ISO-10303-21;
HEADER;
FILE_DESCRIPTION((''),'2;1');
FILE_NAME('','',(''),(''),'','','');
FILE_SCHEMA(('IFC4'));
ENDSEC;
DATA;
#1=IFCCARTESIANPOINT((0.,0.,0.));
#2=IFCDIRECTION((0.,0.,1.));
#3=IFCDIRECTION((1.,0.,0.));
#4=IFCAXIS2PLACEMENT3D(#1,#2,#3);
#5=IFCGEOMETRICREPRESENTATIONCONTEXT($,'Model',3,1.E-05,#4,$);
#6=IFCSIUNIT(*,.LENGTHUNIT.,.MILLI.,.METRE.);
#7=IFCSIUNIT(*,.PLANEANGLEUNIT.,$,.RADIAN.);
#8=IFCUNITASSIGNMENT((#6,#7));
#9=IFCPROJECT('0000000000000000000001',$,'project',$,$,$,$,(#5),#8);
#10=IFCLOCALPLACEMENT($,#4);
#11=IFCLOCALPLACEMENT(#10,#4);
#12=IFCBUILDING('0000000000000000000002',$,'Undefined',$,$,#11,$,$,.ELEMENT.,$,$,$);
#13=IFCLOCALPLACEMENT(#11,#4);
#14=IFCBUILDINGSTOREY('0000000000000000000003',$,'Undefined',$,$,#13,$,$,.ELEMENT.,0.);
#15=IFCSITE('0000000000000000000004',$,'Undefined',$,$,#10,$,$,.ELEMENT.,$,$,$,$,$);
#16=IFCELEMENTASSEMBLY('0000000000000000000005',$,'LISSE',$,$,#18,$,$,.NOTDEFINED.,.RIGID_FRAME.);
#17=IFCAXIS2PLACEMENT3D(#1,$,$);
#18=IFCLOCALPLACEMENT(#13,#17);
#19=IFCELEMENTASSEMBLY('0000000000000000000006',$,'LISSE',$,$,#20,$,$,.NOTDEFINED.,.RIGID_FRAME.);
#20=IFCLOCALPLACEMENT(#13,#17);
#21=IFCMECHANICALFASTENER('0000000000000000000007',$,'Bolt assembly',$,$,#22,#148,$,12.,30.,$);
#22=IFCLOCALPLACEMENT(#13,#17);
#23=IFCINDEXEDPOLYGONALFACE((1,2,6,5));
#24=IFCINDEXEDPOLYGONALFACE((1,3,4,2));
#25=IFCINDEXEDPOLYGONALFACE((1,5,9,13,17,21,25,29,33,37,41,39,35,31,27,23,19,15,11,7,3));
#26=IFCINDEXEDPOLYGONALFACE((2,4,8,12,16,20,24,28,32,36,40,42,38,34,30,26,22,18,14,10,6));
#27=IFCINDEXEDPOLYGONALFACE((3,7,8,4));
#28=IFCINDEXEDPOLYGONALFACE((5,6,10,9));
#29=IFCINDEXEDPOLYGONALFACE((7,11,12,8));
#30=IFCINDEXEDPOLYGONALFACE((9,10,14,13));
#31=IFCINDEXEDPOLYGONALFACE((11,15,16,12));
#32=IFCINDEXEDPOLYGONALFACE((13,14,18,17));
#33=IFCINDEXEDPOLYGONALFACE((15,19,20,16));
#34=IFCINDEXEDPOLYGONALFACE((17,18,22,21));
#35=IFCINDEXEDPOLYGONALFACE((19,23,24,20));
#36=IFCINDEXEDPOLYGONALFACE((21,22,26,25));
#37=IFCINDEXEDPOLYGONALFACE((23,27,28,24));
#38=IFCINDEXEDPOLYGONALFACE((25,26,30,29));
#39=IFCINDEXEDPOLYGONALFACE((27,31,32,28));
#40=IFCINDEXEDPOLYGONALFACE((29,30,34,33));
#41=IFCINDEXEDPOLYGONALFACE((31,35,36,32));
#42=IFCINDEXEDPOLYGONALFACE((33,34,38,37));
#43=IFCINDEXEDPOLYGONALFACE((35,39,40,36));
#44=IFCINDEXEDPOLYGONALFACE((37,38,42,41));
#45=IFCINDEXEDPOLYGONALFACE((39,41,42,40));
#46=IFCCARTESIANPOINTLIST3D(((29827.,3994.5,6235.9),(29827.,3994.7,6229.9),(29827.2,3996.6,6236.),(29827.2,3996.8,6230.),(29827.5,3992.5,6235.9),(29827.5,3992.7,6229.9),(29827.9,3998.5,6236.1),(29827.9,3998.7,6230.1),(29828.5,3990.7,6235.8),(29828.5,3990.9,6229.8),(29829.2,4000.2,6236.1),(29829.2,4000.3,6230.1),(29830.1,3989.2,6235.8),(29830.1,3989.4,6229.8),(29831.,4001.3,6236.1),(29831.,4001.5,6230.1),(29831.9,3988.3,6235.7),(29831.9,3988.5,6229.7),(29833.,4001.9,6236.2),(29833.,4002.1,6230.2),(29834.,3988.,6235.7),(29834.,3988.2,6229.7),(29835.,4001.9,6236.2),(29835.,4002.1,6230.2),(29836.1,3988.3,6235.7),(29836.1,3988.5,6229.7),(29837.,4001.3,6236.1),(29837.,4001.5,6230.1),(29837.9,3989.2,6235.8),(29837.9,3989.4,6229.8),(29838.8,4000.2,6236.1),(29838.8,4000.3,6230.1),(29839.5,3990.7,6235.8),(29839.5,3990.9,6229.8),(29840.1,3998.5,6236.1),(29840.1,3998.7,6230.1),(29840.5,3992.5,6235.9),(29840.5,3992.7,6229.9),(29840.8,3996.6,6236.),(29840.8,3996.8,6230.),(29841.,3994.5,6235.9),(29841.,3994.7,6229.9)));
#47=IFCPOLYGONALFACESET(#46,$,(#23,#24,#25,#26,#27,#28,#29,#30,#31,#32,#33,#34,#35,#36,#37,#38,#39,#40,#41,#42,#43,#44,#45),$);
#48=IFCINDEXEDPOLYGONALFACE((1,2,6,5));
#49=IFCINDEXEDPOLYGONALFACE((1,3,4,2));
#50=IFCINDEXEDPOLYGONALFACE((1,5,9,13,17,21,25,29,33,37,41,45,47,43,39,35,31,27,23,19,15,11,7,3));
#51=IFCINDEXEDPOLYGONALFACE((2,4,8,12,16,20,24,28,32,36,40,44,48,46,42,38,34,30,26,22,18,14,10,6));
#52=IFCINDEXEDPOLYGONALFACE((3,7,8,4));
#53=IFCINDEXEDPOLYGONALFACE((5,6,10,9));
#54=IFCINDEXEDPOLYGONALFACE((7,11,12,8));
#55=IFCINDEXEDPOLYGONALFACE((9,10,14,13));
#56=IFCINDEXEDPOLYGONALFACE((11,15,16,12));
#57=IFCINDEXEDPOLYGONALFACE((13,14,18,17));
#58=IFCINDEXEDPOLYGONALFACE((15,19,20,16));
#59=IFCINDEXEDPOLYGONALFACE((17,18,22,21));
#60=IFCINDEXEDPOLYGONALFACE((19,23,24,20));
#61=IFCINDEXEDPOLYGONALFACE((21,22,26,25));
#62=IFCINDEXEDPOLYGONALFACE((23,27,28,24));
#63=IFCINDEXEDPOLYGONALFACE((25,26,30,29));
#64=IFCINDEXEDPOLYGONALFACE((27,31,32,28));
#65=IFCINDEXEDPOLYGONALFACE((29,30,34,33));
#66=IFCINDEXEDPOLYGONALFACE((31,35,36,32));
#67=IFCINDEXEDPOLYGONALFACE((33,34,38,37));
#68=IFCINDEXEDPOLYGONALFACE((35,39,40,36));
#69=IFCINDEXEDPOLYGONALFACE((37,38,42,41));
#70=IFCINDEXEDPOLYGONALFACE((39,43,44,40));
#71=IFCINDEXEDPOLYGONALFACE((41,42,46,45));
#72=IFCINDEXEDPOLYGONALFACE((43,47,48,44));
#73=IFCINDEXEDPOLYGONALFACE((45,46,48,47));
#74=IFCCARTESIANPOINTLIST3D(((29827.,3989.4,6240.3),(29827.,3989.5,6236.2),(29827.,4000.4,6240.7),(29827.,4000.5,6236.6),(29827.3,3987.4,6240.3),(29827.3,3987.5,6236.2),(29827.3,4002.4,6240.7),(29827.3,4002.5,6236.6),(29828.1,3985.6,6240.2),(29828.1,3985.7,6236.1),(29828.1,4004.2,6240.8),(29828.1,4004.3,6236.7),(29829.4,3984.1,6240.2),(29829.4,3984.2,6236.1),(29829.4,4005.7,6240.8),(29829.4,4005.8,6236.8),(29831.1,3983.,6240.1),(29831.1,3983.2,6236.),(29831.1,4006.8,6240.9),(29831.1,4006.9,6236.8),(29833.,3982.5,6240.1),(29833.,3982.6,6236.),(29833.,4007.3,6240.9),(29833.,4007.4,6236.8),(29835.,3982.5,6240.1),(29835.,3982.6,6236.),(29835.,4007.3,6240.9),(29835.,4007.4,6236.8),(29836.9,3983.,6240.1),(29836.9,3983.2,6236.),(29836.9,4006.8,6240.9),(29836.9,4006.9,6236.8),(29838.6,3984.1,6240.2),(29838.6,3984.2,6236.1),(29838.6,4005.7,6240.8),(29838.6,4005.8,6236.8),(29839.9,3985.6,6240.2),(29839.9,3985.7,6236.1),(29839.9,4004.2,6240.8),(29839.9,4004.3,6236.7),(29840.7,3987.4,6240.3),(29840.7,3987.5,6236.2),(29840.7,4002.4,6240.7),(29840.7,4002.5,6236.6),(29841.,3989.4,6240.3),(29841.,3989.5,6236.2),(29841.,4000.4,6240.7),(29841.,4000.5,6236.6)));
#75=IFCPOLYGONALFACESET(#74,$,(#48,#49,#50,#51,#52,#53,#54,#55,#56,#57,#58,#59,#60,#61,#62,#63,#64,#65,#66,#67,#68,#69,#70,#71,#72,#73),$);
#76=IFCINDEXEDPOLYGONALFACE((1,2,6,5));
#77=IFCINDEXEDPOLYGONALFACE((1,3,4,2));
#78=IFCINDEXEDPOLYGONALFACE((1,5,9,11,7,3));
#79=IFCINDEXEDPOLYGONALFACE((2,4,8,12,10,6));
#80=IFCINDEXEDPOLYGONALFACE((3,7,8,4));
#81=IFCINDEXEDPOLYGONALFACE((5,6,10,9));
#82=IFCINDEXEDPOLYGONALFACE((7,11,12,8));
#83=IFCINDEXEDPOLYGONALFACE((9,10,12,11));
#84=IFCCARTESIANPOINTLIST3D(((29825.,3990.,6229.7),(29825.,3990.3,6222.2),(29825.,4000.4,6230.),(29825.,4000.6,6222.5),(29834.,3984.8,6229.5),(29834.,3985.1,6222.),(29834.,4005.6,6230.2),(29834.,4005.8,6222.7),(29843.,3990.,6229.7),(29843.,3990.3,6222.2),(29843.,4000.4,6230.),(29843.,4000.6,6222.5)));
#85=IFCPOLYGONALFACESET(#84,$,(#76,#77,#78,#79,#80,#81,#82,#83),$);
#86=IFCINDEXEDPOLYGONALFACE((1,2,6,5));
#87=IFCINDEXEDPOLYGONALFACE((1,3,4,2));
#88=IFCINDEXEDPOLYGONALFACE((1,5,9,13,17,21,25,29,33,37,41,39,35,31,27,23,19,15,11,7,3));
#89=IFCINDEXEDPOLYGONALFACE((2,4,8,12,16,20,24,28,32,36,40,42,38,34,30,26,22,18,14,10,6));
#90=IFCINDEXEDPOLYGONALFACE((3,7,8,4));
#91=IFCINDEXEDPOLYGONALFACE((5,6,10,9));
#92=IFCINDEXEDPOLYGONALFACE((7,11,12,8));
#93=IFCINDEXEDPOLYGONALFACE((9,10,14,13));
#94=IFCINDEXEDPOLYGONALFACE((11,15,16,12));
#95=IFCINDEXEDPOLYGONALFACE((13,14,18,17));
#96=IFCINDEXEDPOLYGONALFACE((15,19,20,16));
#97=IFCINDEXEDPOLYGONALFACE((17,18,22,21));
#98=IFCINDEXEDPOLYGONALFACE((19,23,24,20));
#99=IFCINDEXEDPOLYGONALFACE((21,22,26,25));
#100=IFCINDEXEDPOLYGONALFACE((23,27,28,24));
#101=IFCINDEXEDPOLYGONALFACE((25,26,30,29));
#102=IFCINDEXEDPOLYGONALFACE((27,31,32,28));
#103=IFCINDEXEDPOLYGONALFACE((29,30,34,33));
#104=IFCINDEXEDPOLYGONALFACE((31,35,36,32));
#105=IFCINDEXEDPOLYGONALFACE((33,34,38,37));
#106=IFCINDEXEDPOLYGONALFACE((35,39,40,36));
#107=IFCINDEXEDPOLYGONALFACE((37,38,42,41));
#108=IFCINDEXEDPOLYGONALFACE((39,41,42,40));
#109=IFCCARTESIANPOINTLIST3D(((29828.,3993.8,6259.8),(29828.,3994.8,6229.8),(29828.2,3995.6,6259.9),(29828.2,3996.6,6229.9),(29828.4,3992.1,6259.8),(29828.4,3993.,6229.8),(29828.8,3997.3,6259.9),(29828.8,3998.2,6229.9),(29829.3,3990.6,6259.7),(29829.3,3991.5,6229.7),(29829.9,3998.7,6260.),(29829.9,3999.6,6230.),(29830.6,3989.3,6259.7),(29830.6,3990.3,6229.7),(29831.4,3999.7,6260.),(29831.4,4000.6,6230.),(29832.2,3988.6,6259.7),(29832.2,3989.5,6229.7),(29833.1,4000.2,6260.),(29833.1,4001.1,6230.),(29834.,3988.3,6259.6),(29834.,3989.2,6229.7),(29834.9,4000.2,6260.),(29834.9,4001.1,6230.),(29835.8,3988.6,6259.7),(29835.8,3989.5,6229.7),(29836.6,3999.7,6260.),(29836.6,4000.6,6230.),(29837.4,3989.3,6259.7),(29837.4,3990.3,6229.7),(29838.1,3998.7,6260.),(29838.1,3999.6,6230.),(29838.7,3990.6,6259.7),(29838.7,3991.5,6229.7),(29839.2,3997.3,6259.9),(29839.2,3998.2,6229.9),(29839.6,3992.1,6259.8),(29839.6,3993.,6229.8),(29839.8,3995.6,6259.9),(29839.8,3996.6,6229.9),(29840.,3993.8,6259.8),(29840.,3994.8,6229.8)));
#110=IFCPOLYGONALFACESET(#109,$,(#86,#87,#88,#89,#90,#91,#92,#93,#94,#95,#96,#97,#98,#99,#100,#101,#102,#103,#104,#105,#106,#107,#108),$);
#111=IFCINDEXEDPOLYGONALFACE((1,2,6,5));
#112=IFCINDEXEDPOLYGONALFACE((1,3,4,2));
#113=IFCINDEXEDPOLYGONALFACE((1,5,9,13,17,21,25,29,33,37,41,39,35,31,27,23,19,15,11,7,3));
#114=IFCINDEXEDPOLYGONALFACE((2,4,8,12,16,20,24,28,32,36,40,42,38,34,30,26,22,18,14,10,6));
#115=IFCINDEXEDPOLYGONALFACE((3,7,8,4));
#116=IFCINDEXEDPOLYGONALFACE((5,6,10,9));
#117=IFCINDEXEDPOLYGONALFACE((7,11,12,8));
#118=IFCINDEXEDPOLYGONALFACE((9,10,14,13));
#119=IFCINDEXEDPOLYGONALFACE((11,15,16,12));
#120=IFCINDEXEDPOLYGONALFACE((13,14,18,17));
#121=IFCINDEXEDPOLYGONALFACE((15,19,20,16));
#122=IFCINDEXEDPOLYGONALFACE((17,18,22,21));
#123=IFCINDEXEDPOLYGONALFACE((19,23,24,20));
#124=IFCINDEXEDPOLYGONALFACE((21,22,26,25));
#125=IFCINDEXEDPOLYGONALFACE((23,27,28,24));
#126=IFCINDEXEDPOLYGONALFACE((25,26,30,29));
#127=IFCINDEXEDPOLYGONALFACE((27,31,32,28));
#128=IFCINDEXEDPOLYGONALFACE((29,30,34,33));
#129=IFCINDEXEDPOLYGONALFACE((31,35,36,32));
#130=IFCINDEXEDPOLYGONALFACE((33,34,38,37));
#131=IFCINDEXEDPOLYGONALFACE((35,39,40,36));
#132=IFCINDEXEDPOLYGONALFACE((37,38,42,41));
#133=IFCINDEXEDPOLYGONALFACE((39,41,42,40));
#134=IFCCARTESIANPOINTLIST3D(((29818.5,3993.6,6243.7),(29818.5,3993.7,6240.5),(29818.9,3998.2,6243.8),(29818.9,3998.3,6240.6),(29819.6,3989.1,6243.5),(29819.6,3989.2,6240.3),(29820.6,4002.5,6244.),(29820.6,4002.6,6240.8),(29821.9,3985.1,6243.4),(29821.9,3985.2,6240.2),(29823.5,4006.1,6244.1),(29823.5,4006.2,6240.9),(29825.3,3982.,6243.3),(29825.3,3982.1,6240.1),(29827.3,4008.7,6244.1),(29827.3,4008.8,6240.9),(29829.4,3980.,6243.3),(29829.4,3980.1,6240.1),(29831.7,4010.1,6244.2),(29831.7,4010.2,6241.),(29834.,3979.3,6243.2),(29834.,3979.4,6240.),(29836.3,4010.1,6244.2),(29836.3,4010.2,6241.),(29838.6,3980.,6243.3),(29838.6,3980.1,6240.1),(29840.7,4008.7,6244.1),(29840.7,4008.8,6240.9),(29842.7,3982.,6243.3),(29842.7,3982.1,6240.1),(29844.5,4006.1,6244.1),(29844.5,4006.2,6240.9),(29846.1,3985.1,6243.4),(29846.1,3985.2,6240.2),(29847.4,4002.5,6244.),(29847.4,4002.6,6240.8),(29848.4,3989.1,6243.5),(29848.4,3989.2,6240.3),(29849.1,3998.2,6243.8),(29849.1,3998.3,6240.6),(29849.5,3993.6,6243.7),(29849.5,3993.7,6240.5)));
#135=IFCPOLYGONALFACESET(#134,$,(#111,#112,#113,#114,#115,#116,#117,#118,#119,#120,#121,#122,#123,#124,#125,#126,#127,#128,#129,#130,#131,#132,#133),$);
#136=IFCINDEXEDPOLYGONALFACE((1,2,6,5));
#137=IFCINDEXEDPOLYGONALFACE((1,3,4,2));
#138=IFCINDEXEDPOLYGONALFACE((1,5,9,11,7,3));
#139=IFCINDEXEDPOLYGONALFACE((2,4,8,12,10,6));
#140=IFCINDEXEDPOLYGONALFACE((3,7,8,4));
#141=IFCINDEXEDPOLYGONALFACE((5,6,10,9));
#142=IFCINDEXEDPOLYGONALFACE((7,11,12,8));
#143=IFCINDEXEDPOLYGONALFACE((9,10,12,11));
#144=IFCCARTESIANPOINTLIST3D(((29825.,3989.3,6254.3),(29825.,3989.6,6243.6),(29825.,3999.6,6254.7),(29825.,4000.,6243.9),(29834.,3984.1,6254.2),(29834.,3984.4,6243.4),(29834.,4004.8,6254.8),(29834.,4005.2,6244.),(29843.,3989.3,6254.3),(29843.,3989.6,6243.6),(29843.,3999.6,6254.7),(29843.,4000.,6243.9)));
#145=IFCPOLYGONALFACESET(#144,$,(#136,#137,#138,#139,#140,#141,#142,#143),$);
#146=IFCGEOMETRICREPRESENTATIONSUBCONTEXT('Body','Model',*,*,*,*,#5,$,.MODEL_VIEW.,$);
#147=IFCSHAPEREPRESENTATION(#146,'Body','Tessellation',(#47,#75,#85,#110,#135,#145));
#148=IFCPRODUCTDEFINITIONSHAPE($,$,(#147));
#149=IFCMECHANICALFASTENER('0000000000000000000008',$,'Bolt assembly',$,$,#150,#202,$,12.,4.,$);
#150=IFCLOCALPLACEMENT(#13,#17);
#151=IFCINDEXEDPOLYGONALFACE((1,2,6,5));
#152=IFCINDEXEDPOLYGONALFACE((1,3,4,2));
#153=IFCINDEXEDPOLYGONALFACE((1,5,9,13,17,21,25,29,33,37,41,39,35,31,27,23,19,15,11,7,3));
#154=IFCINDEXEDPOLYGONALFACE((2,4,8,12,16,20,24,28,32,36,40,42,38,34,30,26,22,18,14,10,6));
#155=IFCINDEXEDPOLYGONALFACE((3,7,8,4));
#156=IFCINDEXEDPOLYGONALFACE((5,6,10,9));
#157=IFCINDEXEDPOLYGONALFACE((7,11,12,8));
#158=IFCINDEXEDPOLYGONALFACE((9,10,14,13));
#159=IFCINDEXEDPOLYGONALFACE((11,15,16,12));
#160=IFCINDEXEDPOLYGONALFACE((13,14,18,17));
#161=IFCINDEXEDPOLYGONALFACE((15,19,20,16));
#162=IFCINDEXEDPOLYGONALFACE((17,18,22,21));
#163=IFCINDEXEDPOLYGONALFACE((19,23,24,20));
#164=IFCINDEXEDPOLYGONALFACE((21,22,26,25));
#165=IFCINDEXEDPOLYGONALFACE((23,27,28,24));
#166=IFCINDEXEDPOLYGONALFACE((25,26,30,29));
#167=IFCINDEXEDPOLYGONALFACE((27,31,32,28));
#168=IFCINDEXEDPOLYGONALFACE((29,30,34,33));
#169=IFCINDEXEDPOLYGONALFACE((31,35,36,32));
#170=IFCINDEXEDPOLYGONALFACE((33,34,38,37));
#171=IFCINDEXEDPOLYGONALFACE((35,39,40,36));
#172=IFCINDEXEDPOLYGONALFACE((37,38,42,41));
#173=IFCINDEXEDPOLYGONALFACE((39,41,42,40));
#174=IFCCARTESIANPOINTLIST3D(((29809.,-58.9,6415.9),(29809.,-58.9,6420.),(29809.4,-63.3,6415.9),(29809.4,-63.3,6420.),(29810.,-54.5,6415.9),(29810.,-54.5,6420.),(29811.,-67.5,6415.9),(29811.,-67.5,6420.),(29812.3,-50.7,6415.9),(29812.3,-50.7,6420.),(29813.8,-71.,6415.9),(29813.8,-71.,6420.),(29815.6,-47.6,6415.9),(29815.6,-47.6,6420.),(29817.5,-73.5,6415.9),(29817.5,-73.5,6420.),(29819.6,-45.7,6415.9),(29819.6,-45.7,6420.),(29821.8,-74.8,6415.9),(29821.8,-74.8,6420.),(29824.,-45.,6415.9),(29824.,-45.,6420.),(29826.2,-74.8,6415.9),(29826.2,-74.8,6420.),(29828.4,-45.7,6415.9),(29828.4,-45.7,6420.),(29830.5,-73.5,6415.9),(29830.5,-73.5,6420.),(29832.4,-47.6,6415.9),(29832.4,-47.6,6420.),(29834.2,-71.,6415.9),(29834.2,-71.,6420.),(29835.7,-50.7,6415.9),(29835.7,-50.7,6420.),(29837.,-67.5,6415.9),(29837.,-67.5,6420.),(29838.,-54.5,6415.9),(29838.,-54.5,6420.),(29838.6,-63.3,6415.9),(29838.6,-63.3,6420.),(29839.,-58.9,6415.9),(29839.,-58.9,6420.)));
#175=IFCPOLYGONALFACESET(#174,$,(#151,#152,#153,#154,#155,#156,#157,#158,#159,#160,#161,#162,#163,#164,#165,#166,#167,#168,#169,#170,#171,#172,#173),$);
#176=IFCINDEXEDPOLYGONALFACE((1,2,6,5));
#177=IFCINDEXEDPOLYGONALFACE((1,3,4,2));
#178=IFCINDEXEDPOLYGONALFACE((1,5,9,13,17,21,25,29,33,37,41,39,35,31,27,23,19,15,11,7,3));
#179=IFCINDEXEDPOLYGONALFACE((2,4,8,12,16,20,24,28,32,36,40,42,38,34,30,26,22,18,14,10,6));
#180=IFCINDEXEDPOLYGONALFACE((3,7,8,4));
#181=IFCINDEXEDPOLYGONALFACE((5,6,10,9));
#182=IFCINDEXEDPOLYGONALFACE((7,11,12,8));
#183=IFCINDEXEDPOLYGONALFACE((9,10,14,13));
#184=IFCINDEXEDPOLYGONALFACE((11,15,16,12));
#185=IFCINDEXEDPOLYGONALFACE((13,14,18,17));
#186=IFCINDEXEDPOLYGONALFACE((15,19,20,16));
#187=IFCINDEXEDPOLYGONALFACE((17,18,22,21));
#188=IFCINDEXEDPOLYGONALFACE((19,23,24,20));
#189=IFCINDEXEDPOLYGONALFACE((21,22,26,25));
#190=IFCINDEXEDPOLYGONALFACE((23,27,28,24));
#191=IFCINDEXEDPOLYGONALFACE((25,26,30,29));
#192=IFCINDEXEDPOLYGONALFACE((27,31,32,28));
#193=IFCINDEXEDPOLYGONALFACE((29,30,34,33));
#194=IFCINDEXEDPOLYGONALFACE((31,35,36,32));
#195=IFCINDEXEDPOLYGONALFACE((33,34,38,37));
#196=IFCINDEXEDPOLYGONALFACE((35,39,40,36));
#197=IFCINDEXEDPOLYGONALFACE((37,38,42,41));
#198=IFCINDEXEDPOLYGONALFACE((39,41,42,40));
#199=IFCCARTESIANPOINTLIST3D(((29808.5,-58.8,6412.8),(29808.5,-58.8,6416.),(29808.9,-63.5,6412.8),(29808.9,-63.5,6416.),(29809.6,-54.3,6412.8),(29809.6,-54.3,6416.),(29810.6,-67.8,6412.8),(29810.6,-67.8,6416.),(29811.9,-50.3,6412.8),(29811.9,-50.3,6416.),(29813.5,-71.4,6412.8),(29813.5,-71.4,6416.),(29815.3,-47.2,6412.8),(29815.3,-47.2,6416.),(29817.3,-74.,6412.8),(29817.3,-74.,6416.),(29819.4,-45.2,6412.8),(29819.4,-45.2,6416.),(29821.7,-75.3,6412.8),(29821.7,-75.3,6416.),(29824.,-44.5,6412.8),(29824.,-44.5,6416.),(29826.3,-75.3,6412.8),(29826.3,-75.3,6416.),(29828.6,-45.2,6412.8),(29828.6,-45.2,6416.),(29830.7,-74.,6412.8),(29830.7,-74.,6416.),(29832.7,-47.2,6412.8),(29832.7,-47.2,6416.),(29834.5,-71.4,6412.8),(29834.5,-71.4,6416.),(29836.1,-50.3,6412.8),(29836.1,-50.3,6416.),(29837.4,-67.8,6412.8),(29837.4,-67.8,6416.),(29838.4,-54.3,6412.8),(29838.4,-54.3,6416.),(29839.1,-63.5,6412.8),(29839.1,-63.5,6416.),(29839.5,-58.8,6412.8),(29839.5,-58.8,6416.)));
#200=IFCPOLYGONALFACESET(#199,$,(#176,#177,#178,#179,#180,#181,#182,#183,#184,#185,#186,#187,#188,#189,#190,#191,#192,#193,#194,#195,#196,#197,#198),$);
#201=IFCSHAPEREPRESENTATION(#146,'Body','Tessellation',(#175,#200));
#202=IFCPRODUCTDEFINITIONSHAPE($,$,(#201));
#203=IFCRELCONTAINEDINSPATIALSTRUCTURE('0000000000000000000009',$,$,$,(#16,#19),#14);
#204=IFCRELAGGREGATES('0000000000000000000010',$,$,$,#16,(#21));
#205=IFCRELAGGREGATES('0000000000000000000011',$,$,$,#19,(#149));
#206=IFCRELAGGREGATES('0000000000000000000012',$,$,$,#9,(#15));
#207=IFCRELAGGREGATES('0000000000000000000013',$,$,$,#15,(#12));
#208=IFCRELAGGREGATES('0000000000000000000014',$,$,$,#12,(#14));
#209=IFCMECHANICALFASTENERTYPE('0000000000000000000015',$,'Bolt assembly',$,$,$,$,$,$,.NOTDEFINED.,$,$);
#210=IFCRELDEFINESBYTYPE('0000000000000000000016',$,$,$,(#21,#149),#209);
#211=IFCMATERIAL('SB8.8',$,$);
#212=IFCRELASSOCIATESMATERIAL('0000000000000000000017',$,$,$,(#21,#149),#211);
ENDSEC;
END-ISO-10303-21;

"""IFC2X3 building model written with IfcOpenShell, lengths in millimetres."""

from ifc_helpers import new_model, si_unit, frame, frame_2d, origin_with_axes, origin_2d_with_axis, place, context, subcontext, project, spatial, polyline, circle_curve, parameter, trimmed, segment, composite_curve, circle, outline, extrude, source, transform, mapped, material, type_object, element, aggregate, save


model = new_model("IFC2X3")

# Units and contexts
model_context = context("Model", 3, precision=1e-05, world=origin_with_axes())
body_context = subcontext(model_context, "Body", "Model", "MODEL_VIEW")
ifc_project = project(units=[si_unit("LENGTHUNIT", "METRE", prefix="MILLI"), si_unit("PLANEANGLEUNIT", "RADIAN")], contexts=[model_context])

# Site, building, storey
site_placement = place(None, origin_with_axes())
site = spatial("IfcSite", under=ifc_project, at=site_placement, Name="Undefined", CompositionType="ELEMENT")
building_placement = place(site_placement, origin_with_axes())
building = spatial("IfcBuilding", under=site, at=building_placement, Name="Undefined", CompositionType="ELEMENT")
storey_placement = place(building_placement, origin_with_axes())
storey = spatial("IfcBuildingStorey", under=building, at=storey_placement, Name="Undefined", CompositionType="ELEMENT", Elevation=0.0)

# Element assemblies
assembly_1_placement = place(storey_placement, origin_with_axes())
assembly_1 = element("IfcElementAssembly", 1, at=assembly_1_placement, inside=storey, Name="LISSE", AssemblyPlace="NOTDEFINED", PredefinedType="RIGID_FRAME")
assembly_2_placement = place(storey_placement, origin_with_axes())
assembly_2 = element("IfcElementAssembly", 2, at=assembly_2_placement, inside=storey, Name="LISSE", AssemblyPlace="NOTDEFINED", PredefinedType="RIGID_FRAME")

# Shared definitions
ifc_material_1 = material(Name="SB8.8")
mechanical_fastener_type = type_object("IfcMechanicalFastenerType", Name="Bolt assembly")

# Mechanical fasteners
shared_shape_1 = source(origin_with_axes(), body_context, "Body", "SweptSolid", [
    extrude(circle(Radius=7.0, at=origin_2d_with_axis()), frame((0.0, -6.6, 0.0), z_axis=(0.0, 1.0, 0.0), x_axis=(1.0, 0.0, 0.0)), (0.0, 0.0, 1.0), 6.0),
    extrude(outline(composite_curve([segment(polyline([(-5.5, 7.0), (5.5, 7.0)]), True, "CONTINUOUS"), segment(trimmed(circle_curve(frame_2d((5.5, 0.0), x_axis=(0.0, 1.0)), 7.0), [parameter(0.0)], [parameter(3.141593)], False, "PARAMETER"), True, "CONTINUOUS"), segment(polyline([(5.5, -7.0), (-5.5, -7.0)]), True, "CONTINUOUS"), segment(trimmed(circle_curve(frame_2d((-5.5, 0.0), x_axis=(0.0, -1.0)), 7.0), [parameter(0.0)], [parameter(3.141593)], False, "PARAMETER"), True, "DISCONTINUOUS")], self_intersect=False)), frame((0.0, -0.1, 0.0), z_axis=(0.0, 1.0, 0.0), x_axis=(1.0, 0.0, 0.0)), (0.0, 0.0, 1.0), 4.1),
    extrude(outline(polyline([(10.4, 0.0), (5.2, 9.0), (-5.2, 9.0), (-10.4, 0.0), (-5.2, -9.0), (5.2, -9.0), (10.4, 0.0)])), frame((0.0, -14.2, 0.0), z_axis=(0.0, 1.0, 0.0), x_axis=(1.0, 0.0, 0.0)), (0.0, 0.0, 1.0), 7.5),
    extrude(circle(Radius=6.0, at=origin_2d_with_axis()), frame((0.0, -6.7, 0.0), z_axis=(0.0, 1.0, 0.0), x_axis=(1.0, 0.0, 0.0)), (0.0, 0.0, 1.0), 30.0),
    extrude(circle(Radius=15.5, at=origin_2d_with_axis()), frame((0.0, 4.0, 0.0), z_axis=(0.0, 1.0, 0.0), x_axis=(1.0, 0.0, 0.0)), (0.0, 0.0, 1.0), 3.2),
    extrude(outline(polyline([(10.4, 0.0), (5.2, 9.0), (-5.2, 9.0), (-10.4, 0.0), (-5.2, -9.0), (5.2, -9.0), (10.4, 0.0)])), frame((0.0, 7.2, 0.0), z_axis=(0.0, 1.0, 0.0), x_axis=(1.0, 0.0, 0.0)), (0.0, 0.0, 1.0), 10.8),
])
mechanical_fastener_1_placement = place(assembly_1_placement, frame((29834.0, 3995.0, 6236.5), z_axis=(-1.0, 0.0, 0.0), x_axis=(0.0, -0.99952, -0.030984)))
mechanical_fastener_1 = element("IfcMechanicalFastener", 3, at=mechanical_fastener_1_placement, type_object=mechanical_fastener_type, material=ifc_material_1, Name="Bolt assembly", NominalDiameter=12.0, NominalLength=30.0, context=body_context, shape_type="MappedRepresentation", body=[
    mapped(shared_shape_1, transform((0.0, 0.0, 0.0))),
])
aggregate(assembly_1, [mechanical_fastener_1])
shared_shape_2 = source(origin_with_axes(), body_context, "Body", "SweptSolid", [
    extrude(circle(Radius=15.0, at=origin_2d_with_axis()), frame((0.0, -10.0, 0.0), z_axis=(0.0, 1.0, 0.0), x_axis=(1.0, 0.0, 0.0)), (0.0, 0.0, 1.0), 4.1),
    extrude(circle(Radius=15.5, at=origin_2d_with_axis()), frame((0.0, -6.0, 0.0), z_axis=(0.0, 1.0, 0.0), x_axis=(1.0, 0.0, 0.0)), (0.0, 0.0, 1.0), 3.2),
])
mechanical_fastener_2_placement = place(assembly_2_placement, frame((29824.0, -60.0, 6410.0), z_axis=(-1.0, 0.0, 0.0), x_axis=(0.0, 1.0, 0.0)))
mechanical_fastener_2 = element("IfcMechanicalFastener", 4, at=mechanical_fastener_2_placement, type_object=mechanical_fastener_type, material=ifc_material_1, Name="Bolt assembly", NominalDiameter=12.0, NominalLength=4.0, context=body_context, shape_type="MappedRepresentation", body=[
    mapped(shared_shape_2, transform((0.0, 0.0, 0.0))),
])
aggregate(assembly_2, [mechanical_fastener_2])

save(model, "model.ifc")
